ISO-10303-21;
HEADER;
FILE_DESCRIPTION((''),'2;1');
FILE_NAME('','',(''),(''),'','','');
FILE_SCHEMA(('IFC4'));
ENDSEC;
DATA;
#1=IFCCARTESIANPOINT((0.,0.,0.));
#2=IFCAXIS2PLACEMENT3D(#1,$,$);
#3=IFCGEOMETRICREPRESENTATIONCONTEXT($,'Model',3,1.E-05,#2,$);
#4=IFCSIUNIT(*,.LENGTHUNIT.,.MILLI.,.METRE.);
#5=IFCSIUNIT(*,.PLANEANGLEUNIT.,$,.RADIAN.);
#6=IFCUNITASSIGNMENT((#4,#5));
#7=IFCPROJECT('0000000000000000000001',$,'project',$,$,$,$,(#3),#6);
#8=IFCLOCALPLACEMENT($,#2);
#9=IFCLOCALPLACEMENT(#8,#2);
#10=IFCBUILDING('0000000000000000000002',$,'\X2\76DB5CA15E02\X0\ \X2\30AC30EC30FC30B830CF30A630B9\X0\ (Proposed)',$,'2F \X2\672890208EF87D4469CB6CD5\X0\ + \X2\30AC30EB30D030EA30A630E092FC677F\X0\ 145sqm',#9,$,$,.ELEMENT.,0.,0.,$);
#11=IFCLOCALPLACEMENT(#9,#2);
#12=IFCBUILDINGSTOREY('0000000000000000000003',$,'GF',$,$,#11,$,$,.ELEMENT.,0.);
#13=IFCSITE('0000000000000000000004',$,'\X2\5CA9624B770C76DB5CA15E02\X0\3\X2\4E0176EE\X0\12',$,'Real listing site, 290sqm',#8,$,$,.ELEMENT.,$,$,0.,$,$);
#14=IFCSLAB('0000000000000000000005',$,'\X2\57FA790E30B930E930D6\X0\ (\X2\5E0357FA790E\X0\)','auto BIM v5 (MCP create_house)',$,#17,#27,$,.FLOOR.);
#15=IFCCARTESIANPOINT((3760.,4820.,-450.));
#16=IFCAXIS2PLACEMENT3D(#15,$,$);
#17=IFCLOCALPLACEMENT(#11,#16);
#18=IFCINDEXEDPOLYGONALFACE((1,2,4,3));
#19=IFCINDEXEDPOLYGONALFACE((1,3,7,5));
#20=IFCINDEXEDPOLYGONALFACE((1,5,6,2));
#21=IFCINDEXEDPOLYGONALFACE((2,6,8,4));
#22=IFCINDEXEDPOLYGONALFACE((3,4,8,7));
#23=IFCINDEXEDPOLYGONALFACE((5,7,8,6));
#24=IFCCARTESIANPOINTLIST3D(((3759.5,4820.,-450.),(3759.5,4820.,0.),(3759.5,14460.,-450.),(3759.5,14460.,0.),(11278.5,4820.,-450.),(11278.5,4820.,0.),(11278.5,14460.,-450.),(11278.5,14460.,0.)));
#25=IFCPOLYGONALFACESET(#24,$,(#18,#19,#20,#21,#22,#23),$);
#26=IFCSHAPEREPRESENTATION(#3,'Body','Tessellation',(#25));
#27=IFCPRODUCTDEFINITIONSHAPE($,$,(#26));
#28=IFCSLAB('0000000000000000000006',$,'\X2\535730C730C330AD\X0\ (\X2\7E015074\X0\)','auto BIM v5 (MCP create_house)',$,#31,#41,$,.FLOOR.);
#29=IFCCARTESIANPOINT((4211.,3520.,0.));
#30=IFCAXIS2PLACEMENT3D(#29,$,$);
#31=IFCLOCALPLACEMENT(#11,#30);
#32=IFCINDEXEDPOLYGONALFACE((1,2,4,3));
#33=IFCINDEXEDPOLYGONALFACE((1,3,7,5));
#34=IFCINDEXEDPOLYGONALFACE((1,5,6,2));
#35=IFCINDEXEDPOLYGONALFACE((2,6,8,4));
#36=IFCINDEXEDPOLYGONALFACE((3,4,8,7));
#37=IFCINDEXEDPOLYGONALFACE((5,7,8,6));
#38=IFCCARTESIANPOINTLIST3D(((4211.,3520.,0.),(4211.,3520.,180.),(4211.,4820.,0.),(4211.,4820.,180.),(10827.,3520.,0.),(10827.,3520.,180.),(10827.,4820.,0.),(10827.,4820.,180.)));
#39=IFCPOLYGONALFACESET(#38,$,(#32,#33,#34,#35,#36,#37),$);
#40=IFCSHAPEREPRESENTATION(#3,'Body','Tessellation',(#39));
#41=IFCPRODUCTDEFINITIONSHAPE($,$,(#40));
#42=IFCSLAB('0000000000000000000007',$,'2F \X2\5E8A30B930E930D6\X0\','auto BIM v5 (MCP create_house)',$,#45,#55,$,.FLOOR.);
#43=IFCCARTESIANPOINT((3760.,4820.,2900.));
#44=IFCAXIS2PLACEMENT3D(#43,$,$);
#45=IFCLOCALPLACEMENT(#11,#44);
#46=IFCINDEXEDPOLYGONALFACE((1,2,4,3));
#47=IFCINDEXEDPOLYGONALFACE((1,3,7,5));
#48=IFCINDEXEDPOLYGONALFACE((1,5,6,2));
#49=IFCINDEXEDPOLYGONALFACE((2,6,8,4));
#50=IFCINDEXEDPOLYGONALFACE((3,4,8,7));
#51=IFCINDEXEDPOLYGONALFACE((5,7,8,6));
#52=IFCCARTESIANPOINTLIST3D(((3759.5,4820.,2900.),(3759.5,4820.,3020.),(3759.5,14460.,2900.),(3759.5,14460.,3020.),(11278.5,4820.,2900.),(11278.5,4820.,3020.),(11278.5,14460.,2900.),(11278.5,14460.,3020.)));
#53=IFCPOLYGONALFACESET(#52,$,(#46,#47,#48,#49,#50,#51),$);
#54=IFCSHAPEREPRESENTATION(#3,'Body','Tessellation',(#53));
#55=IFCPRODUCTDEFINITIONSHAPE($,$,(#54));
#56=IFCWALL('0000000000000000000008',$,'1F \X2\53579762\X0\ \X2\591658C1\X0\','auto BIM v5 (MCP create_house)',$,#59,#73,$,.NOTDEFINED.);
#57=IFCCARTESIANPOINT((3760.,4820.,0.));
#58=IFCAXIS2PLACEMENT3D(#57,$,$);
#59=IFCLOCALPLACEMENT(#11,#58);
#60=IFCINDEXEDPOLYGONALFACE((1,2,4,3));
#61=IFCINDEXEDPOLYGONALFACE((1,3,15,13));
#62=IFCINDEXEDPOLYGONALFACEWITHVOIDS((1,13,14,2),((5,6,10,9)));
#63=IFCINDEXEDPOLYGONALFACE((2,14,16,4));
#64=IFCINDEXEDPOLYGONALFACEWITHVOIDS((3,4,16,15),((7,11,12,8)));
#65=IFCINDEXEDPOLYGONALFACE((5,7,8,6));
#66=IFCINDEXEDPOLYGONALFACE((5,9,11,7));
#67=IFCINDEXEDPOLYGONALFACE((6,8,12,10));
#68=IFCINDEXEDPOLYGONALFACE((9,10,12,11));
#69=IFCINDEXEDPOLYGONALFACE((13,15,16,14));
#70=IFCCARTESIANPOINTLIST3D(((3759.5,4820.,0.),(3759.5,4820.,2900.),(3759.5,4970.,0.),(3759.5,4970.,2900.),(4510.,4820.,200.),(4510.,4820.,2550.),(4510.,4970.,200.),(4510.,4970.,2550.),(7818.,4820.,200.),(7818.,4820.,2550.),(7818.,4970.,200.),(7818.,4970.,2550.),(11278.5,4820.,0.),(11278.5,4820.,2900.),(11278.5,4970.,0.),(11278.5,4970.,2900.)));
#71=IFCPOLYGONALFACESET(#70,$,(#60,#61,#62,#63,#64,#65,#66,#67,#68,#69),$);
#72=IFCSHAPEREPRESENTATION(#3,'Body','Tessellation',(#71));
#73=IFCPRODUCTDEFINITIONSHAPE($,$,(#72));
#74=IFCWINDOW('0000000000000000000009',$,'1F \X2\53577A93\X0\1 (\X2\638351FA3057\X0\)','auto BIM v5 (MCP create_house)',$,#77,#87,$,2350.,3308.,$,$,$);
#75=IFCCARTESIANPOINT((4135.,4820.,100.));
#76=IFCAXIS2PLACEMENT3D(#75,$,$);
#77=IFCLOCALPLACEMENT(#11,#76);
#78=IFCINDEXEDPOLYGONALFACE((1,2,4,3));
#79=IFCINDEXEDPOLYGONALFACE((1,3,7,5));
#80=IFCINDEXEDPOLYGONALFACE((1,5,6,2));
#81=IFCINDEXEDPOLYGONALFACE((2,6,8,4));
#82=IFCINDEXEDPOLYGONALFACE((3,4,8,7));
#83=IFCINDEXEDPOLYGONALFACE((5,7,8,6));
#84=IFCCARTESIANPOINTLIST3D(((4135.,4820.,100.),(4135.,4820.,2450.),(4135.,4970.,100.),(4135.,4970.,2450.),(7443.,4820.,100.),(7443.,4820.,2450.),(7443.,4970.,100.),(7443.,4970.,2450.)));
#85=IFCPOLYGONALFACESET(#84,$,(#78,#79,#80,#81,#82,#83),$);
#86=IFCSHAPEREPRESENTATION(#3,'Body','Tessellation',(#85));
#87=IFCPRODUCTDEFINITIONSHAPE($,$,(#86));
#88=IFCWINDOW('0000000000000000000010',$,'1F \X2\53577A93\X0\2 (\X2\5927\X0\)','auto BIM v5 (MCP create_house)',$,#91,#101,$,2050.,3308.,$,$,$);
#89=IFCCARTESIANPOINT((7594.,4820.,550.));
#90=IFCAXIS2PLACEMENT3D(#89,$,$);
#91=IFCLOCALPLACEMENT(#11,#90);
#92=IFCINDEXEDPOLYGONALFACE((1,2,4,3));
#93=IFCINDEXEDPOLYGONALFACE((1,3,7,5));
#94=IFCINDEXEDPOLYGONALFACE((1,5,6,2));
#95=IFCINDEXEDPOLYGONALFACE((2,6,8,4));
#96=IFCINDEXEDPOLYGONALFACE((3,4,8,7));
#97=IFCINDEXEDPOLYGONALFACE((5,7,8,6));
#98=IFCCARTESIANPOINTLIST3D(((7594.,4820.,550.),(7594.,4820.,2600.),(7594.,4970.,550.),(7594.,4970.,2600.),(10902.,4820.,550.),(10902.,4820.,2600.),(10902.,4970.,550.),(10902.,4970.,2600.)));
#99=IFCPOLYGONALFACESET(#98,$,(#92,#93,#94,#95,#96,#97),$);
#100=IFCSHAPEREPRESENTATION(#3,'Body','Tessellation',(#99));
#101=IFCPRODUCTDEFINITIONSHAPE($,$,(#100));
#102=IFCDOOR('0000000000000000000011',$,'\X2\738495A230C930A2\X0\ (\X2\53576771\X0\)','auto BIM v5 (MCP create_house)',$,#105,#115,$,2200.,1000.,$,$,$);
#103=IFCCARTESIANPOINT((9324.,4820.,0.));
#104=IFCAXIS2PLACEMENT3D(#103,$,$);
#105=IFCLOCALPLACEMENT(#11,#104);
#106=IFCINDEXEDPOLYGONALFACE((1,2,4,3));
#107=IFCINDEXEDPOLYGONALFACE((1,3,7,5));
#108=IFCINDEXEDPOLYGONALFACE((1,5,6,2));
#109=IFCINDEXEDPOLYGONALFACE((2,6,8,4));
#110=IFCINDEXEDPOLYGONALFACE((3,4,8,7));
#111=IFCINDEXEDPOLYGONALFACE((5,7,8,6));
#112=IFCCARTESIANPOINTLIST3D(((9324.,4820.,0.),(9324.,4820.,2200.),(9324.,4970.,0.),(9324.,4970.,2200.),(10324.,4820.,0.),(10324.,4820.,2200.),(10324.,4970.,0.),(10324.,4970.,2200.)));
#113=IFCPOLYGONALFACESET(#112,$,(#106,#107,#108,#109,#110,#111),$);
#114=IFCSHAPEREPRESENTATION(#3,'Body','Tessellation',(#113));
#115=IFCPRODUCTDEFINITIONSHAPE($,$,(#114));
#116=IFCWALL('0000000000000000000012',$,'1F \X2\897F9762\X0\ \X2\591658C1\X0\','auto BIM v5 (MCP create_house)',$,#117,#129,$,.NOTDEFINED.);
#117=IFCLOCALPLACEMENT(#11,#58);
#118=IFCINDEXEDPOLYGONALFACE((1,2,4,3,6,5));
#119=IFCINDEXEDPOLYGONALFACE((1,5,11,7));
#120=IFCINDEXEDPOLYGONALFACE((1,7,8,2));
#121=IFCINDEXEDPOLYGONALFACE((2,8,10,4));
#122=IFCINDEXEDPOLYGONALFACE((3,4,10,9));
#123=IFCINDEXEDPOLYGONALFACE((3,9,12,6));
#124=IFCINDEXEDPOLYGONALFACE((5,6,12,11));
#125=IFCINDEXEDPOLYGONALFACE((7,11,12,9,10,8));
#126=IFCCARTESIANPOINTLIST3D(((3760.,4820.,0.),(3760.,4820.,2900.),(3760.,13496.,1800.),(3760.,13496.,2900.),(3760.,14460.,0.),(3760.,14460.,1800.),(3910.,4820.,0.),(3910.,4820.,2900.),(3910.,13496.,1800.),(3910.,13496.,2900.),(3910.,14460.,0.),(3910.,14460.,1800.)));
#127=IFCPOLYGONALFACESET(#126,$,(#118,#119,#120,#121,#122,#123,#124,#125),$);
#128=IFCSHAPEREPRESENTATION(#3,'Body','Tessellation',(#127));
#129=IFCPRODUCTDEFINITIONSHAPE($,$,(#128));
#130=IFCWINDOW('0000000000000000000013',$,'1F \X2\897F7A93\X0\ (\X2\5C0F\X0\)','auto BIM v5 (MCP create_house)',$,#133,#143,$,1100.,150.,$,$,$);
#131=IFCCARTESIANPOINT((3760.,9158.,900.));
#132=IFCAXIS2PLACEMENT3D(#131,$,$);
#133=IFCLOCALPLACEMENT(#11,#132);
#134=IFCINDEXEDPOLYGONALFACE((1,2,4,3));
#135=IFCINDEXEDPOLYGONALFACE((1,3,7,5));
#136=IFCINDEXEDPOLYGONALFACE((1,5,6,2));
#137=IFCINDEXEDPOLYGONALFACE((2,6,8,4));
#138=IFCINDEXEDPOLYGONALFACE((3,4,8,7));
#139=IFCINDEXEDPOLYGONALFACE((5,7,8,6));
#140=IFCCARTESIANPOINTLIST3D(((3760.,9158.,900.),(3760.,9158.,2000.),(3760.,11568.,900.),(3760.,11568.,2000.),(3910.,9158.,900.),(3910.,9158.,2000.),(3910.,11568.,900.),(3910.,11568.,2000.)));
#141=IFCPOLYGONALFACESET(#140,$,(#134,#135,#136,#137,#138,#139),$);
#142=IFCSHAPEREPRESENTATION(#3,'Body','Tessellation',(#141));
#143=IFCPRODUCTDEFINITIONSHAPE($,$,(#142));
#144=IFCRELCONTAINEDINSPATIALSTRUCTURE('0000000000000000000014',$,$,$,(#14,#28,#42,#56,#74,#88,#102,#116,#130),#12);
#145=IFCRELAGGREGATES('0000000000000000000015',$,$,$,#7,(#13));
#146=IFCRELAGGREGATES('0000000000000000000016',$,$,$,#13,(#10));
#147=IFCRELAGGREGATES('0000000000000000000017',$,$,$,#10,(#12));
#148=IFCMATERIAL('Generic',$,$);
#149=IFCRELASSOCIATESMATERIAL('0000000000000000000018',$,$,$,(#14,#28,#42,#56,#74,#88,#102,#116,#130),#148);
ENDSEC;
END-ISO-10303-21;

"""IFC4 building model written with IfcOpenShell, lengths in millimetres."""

from ifc_helpers import new_model, si_unit, frame, frame_2d, origin, place, context, project, spatial, rectangle, extrude, material, element, fill, save


model = new_model("IFC4")

# Units and contexts
model_context = context("Model", 3, precision=1e-05, world=origin())
ifc_project = project(units=[si_unit("LENGTHUNIT", "METRE", prefix="MILLI"), si_unit("PLANEANGLEUNIT", "RADIAN")], contexts=[model_context])

# Site, building, storey
site_placement = place(None, origin())
site = spatial("IfcSite", under=ifc_project, at=site_placement, Name="岩手県盛岡市3丁目12", ObjectType="Real listing site, 290sqm", CompositionType="ELEMENT", RefElevation=0.0)
building_placement = place(site_placement, origin())
building = spatial("IfcBuilding", under=site, at=building_placement, Name="盛岡市 ガレージハウス (Proposed)", ObjectType="2F 木造軸組構法 + ガルバリウム鋼板 145sqm", CompositionType="ELEMENT", ElevationOfRefHeight=0.0, ElevationOfTerrain=0.0)
storey_placement = place(building_placement, origin())
storey = spatial("IfcBuildingStorey", under=building, at=storey_placement, Name="GF", CompositionType="ELEMENT", Elevation=0.0)

# Slabs
ifc_material = material(Name="Generic")
slab_1_placement = place(storey_placement, frame((3760.0, 4820.0, -450.0)))
element("IfcSlab", 1, at=slab_1_placement, inside=storey, material=ifc_material, Name="基礎スラブ (布基礎)", Description="auto BIM v5 (MCP create_house)", PredefinedType="FLOOR", context=model_context, shape_type="SweptSolid", body=[
    extrude(rectangle(XDim=7519.0, YDim=9640.0, at=frame_2d((3759.0, 4820.0))), frame((3760.0, 4820.0, -450.0)), (0.0, 0.0, 1.0), 450.0),
])
slab_2_placement = place(storey_placement, frame((4211.0, 3520.0, 0.0)))
element("IfcSlab", 2, at=slab_2_placement, inside=storey, material=ifc_material, Name="南デッキ (縁側)", Description="auto BIM v5 (MCP create_house)", PredefinedType="FLOOR", context=model_context, shape_type="SweptSolid", body=[
    extrude(rectangle(XDim=6616.0, YDim=1300.0, at=frame_2d((3308.0, 650.0))), frame((4211.0, 3520.0, 0.0)), (0.0, 0.0, 1.0), 180.0),
])
slab_3_placement = place(storey_placement, frame((3760.0, 4820.0, 2900.0)))
element("IfcSlab", 3, at=slab_3_placement, inside=storey, material=ifc_material, Name="2F 床スラブ", Description="auto BIM v5 (MCP create_house)", PredefinedType="FLOOR", context=model_context, shape_type="SweptSolid", body=[
    extrude(rectangle(XDim=7519.0, YDim=9640.0, at=frame_2d((3759.0, 4820.0))), frame((3760.0, 4820.0, 2900.0)), (0.0, 0.0, 1.0), 120.0),
])

# Wall, openings, windows, door
wall_1_placement = place(storey_placement, frame((3760.0, 4820.0, 0.0)))
wall_1 = element("IfcWall", 4, at=wall_1_placement, inside=storey, material=ifc_material, Name="1F 南面 外壁", Description="auto BIM v5 (MCP create_house)", PredefinedType="NOTDEFINED", context=model_context, shape_type="SweptSolid", body=[
    extrude(rectangle(XDim=7519.0, YDim=150.0, at=frame_2d((3759.0, 75.0))), frame((3760.0, 4820.0, 0.0)), (0.0, 0.0, 1.0), 2900.0),
])
opening_1_placement = place(storey_placement, frame((4135.0, 4820.0, 100.0)))
opening_1 = element("IfcOpeningElement", 5, at=opening_1_placement, cuts=wall_1, PredefinedType="NOTDEFINED", context=model_context, shape_type="SweptSolid", body=[
    extrude(rectangle(XDim=3308.0, YDim=150.0, at=frame_2d((1654.0, 75.0))), frame((4135.0, 4820.0, 100.0)), (0.0, 0.0, 1.0), 2350.0),
])
opening_2_placement = place(storey_placement, frame((7594.0, 4820.0, 550.0)))
opening_2 = element("IfcOpeningElement", 6, at=opening_2_placement, cuts=wall_1, PredefinedType="NOTDEFINED", context=model_context, shape_type="SweptSolid", body=[
    extrude(rectangle(XDim=3308.0, YDim=150.0, at=frame_2d((1654.0, 75.0))), frame((7594.0, 4820.0, 550.0)), (0.0, 0.0, 1.0), 2050.0),
])
opening_3_placement = place(storey_placement, frame((9324.0, 4820.0, 0.0)))
opening_3 = element("IfcOpeningElement", 7, at=opening_3_placement, cuts=wall_1, PredefinedType="NOTDEFINED", context=model_context, shape_type="SweptSolid", body=[
    extrude(rectangle(XDim=1000.0, YDim=150.0, at=frame_2d((500.0, 75.0))), frame((9324.0, 4820.0, 0.0)), (0.0, 0.0, 1.0), 2200.0),
])
window_1_placement = place(storey_placement, frame((4135.0, 4820.0, 100.0)))
window_1 = element("IfcWindow", 8, at=window_1_placement, inside=storey, material=ifc_material, Name="1F 南窓1 (掃出し)", Description="auto BIM v5 (MCP create_house)", OverallHeight=2350.0, OverallWidth=3308.0, context=model_context, shape_type="SweptSolid", body=[
    extrude(rectangle(XDim=3308.0, YDim=150.0, at=frame_2d((1654.0, 75.0))), frame((4135.0, 4820.0, 100.0)), (0.0, 0.0, 1.0), 2350.0),
])
fill(opening_1, window_1)
window_2_placement = place(storey_placement, frame((7594.0, 4820.0, 550.0)))
window_2 = element("IfcWindow", 9, at=window_2_placement, inside=storey, material=ifc_material, Name="1F 南窓2 (大)", Description="auto BIM v5 (MCP create_house)", OverallHeight=2050.0, OverallWidth=3308.0, context=model_context, shape_type="SweptSolid", body=[
    extrude(rectangle(XDim=3308.0, YDim=150.0, at=frame_2d((1654.0, 75.0))), frame((7594.0, 4820.0, 550.0)), (0.0, 0.0, 1.0), 2050.0),
])
fill(opening_2, window_2)
door_placement = place(storey_placement, frame((9324.0, 4820.0, 0.0)))
door = element("IfcDoor", 10, at=door_placement, inside=storey, material=ifc_material, Name="玄関ドア (南東)", Description="auto BIM v5 (MCP create_house)", OverallHeight=2200.0, OverallWidth=1000.0, context=model_context, shape_type="SweptSolid", body=[
    extrude(rectangle(XDim=1000.0, YDim=150.0, at=frame_2d((500.0, 75.0))), frame((9324.0, 4820.0, 0.0)), (0.0, 0.0, 1.0), 2200.0),
])
fill(opening_3, door)

# Wall, opening, window
wall_2_placement = place(storey_placement, frame((3760.0, 4820.0, 0.0)))
wall_2 = element("IfcWall", 11, at=wall_2_placement, inside=storey, material=ifc_material, Name="1F 西面 外壁", Description="auto BIM v5 (MCP create_house)", PredefinedType="NOTDEFINED", context=model_context, shape_type="SweptSolid", body=[
    extrude(rectangle(XDim=150.0, YDim=9640.0, at=frame_2d((75.0, 4820.0))), frame((3760.0, 4820.0, 0.0)), (0.0, 0.0, 1.0), 2900.0),
])
opening_4_placement = place(storey_placement, frame((3760.0, 9158.0, 900.0)))
opening_4 = element("IfcOpeningElement", 12, at=opening_4_placement, cuts=wall_2, PredefinedType="NOTDEFINED", context=model_context, shape_type="SweptSolid", body=[
    extrude(rectangle(XDim=150.0, YDim=2410.0, at=frame_2d((75.0, 1205.0))), frame((3760.0, 9158.0, 900.0)), (0.0, 0.0, 1.0), 1100.0),
])
window_3_placement = place(storey_placement, frame((3760.0, 9158.0, 900.0)))
window_3 = element("IfcWindow", 13, at=window_3_placement, inside=storey, material=ifc_material, Name="1F 西窓 (小)", Description="auto BIM v5 (MCP create_house)", OverallHeight=1100.0, OverallWidth=150.0, context=model_context, shape_type="SweptSolid", body=[
    extrude(rectangle(XDim=150.0, YDim=2410.0, at=frame_2d((75.0, 1205.0))), frame((3760.0, 9158.0, 900.0)), (0.0, 0.0, 1.0), 1100.0),
])
fill(opening_4, window_3)

save(model, "model.ifc")
